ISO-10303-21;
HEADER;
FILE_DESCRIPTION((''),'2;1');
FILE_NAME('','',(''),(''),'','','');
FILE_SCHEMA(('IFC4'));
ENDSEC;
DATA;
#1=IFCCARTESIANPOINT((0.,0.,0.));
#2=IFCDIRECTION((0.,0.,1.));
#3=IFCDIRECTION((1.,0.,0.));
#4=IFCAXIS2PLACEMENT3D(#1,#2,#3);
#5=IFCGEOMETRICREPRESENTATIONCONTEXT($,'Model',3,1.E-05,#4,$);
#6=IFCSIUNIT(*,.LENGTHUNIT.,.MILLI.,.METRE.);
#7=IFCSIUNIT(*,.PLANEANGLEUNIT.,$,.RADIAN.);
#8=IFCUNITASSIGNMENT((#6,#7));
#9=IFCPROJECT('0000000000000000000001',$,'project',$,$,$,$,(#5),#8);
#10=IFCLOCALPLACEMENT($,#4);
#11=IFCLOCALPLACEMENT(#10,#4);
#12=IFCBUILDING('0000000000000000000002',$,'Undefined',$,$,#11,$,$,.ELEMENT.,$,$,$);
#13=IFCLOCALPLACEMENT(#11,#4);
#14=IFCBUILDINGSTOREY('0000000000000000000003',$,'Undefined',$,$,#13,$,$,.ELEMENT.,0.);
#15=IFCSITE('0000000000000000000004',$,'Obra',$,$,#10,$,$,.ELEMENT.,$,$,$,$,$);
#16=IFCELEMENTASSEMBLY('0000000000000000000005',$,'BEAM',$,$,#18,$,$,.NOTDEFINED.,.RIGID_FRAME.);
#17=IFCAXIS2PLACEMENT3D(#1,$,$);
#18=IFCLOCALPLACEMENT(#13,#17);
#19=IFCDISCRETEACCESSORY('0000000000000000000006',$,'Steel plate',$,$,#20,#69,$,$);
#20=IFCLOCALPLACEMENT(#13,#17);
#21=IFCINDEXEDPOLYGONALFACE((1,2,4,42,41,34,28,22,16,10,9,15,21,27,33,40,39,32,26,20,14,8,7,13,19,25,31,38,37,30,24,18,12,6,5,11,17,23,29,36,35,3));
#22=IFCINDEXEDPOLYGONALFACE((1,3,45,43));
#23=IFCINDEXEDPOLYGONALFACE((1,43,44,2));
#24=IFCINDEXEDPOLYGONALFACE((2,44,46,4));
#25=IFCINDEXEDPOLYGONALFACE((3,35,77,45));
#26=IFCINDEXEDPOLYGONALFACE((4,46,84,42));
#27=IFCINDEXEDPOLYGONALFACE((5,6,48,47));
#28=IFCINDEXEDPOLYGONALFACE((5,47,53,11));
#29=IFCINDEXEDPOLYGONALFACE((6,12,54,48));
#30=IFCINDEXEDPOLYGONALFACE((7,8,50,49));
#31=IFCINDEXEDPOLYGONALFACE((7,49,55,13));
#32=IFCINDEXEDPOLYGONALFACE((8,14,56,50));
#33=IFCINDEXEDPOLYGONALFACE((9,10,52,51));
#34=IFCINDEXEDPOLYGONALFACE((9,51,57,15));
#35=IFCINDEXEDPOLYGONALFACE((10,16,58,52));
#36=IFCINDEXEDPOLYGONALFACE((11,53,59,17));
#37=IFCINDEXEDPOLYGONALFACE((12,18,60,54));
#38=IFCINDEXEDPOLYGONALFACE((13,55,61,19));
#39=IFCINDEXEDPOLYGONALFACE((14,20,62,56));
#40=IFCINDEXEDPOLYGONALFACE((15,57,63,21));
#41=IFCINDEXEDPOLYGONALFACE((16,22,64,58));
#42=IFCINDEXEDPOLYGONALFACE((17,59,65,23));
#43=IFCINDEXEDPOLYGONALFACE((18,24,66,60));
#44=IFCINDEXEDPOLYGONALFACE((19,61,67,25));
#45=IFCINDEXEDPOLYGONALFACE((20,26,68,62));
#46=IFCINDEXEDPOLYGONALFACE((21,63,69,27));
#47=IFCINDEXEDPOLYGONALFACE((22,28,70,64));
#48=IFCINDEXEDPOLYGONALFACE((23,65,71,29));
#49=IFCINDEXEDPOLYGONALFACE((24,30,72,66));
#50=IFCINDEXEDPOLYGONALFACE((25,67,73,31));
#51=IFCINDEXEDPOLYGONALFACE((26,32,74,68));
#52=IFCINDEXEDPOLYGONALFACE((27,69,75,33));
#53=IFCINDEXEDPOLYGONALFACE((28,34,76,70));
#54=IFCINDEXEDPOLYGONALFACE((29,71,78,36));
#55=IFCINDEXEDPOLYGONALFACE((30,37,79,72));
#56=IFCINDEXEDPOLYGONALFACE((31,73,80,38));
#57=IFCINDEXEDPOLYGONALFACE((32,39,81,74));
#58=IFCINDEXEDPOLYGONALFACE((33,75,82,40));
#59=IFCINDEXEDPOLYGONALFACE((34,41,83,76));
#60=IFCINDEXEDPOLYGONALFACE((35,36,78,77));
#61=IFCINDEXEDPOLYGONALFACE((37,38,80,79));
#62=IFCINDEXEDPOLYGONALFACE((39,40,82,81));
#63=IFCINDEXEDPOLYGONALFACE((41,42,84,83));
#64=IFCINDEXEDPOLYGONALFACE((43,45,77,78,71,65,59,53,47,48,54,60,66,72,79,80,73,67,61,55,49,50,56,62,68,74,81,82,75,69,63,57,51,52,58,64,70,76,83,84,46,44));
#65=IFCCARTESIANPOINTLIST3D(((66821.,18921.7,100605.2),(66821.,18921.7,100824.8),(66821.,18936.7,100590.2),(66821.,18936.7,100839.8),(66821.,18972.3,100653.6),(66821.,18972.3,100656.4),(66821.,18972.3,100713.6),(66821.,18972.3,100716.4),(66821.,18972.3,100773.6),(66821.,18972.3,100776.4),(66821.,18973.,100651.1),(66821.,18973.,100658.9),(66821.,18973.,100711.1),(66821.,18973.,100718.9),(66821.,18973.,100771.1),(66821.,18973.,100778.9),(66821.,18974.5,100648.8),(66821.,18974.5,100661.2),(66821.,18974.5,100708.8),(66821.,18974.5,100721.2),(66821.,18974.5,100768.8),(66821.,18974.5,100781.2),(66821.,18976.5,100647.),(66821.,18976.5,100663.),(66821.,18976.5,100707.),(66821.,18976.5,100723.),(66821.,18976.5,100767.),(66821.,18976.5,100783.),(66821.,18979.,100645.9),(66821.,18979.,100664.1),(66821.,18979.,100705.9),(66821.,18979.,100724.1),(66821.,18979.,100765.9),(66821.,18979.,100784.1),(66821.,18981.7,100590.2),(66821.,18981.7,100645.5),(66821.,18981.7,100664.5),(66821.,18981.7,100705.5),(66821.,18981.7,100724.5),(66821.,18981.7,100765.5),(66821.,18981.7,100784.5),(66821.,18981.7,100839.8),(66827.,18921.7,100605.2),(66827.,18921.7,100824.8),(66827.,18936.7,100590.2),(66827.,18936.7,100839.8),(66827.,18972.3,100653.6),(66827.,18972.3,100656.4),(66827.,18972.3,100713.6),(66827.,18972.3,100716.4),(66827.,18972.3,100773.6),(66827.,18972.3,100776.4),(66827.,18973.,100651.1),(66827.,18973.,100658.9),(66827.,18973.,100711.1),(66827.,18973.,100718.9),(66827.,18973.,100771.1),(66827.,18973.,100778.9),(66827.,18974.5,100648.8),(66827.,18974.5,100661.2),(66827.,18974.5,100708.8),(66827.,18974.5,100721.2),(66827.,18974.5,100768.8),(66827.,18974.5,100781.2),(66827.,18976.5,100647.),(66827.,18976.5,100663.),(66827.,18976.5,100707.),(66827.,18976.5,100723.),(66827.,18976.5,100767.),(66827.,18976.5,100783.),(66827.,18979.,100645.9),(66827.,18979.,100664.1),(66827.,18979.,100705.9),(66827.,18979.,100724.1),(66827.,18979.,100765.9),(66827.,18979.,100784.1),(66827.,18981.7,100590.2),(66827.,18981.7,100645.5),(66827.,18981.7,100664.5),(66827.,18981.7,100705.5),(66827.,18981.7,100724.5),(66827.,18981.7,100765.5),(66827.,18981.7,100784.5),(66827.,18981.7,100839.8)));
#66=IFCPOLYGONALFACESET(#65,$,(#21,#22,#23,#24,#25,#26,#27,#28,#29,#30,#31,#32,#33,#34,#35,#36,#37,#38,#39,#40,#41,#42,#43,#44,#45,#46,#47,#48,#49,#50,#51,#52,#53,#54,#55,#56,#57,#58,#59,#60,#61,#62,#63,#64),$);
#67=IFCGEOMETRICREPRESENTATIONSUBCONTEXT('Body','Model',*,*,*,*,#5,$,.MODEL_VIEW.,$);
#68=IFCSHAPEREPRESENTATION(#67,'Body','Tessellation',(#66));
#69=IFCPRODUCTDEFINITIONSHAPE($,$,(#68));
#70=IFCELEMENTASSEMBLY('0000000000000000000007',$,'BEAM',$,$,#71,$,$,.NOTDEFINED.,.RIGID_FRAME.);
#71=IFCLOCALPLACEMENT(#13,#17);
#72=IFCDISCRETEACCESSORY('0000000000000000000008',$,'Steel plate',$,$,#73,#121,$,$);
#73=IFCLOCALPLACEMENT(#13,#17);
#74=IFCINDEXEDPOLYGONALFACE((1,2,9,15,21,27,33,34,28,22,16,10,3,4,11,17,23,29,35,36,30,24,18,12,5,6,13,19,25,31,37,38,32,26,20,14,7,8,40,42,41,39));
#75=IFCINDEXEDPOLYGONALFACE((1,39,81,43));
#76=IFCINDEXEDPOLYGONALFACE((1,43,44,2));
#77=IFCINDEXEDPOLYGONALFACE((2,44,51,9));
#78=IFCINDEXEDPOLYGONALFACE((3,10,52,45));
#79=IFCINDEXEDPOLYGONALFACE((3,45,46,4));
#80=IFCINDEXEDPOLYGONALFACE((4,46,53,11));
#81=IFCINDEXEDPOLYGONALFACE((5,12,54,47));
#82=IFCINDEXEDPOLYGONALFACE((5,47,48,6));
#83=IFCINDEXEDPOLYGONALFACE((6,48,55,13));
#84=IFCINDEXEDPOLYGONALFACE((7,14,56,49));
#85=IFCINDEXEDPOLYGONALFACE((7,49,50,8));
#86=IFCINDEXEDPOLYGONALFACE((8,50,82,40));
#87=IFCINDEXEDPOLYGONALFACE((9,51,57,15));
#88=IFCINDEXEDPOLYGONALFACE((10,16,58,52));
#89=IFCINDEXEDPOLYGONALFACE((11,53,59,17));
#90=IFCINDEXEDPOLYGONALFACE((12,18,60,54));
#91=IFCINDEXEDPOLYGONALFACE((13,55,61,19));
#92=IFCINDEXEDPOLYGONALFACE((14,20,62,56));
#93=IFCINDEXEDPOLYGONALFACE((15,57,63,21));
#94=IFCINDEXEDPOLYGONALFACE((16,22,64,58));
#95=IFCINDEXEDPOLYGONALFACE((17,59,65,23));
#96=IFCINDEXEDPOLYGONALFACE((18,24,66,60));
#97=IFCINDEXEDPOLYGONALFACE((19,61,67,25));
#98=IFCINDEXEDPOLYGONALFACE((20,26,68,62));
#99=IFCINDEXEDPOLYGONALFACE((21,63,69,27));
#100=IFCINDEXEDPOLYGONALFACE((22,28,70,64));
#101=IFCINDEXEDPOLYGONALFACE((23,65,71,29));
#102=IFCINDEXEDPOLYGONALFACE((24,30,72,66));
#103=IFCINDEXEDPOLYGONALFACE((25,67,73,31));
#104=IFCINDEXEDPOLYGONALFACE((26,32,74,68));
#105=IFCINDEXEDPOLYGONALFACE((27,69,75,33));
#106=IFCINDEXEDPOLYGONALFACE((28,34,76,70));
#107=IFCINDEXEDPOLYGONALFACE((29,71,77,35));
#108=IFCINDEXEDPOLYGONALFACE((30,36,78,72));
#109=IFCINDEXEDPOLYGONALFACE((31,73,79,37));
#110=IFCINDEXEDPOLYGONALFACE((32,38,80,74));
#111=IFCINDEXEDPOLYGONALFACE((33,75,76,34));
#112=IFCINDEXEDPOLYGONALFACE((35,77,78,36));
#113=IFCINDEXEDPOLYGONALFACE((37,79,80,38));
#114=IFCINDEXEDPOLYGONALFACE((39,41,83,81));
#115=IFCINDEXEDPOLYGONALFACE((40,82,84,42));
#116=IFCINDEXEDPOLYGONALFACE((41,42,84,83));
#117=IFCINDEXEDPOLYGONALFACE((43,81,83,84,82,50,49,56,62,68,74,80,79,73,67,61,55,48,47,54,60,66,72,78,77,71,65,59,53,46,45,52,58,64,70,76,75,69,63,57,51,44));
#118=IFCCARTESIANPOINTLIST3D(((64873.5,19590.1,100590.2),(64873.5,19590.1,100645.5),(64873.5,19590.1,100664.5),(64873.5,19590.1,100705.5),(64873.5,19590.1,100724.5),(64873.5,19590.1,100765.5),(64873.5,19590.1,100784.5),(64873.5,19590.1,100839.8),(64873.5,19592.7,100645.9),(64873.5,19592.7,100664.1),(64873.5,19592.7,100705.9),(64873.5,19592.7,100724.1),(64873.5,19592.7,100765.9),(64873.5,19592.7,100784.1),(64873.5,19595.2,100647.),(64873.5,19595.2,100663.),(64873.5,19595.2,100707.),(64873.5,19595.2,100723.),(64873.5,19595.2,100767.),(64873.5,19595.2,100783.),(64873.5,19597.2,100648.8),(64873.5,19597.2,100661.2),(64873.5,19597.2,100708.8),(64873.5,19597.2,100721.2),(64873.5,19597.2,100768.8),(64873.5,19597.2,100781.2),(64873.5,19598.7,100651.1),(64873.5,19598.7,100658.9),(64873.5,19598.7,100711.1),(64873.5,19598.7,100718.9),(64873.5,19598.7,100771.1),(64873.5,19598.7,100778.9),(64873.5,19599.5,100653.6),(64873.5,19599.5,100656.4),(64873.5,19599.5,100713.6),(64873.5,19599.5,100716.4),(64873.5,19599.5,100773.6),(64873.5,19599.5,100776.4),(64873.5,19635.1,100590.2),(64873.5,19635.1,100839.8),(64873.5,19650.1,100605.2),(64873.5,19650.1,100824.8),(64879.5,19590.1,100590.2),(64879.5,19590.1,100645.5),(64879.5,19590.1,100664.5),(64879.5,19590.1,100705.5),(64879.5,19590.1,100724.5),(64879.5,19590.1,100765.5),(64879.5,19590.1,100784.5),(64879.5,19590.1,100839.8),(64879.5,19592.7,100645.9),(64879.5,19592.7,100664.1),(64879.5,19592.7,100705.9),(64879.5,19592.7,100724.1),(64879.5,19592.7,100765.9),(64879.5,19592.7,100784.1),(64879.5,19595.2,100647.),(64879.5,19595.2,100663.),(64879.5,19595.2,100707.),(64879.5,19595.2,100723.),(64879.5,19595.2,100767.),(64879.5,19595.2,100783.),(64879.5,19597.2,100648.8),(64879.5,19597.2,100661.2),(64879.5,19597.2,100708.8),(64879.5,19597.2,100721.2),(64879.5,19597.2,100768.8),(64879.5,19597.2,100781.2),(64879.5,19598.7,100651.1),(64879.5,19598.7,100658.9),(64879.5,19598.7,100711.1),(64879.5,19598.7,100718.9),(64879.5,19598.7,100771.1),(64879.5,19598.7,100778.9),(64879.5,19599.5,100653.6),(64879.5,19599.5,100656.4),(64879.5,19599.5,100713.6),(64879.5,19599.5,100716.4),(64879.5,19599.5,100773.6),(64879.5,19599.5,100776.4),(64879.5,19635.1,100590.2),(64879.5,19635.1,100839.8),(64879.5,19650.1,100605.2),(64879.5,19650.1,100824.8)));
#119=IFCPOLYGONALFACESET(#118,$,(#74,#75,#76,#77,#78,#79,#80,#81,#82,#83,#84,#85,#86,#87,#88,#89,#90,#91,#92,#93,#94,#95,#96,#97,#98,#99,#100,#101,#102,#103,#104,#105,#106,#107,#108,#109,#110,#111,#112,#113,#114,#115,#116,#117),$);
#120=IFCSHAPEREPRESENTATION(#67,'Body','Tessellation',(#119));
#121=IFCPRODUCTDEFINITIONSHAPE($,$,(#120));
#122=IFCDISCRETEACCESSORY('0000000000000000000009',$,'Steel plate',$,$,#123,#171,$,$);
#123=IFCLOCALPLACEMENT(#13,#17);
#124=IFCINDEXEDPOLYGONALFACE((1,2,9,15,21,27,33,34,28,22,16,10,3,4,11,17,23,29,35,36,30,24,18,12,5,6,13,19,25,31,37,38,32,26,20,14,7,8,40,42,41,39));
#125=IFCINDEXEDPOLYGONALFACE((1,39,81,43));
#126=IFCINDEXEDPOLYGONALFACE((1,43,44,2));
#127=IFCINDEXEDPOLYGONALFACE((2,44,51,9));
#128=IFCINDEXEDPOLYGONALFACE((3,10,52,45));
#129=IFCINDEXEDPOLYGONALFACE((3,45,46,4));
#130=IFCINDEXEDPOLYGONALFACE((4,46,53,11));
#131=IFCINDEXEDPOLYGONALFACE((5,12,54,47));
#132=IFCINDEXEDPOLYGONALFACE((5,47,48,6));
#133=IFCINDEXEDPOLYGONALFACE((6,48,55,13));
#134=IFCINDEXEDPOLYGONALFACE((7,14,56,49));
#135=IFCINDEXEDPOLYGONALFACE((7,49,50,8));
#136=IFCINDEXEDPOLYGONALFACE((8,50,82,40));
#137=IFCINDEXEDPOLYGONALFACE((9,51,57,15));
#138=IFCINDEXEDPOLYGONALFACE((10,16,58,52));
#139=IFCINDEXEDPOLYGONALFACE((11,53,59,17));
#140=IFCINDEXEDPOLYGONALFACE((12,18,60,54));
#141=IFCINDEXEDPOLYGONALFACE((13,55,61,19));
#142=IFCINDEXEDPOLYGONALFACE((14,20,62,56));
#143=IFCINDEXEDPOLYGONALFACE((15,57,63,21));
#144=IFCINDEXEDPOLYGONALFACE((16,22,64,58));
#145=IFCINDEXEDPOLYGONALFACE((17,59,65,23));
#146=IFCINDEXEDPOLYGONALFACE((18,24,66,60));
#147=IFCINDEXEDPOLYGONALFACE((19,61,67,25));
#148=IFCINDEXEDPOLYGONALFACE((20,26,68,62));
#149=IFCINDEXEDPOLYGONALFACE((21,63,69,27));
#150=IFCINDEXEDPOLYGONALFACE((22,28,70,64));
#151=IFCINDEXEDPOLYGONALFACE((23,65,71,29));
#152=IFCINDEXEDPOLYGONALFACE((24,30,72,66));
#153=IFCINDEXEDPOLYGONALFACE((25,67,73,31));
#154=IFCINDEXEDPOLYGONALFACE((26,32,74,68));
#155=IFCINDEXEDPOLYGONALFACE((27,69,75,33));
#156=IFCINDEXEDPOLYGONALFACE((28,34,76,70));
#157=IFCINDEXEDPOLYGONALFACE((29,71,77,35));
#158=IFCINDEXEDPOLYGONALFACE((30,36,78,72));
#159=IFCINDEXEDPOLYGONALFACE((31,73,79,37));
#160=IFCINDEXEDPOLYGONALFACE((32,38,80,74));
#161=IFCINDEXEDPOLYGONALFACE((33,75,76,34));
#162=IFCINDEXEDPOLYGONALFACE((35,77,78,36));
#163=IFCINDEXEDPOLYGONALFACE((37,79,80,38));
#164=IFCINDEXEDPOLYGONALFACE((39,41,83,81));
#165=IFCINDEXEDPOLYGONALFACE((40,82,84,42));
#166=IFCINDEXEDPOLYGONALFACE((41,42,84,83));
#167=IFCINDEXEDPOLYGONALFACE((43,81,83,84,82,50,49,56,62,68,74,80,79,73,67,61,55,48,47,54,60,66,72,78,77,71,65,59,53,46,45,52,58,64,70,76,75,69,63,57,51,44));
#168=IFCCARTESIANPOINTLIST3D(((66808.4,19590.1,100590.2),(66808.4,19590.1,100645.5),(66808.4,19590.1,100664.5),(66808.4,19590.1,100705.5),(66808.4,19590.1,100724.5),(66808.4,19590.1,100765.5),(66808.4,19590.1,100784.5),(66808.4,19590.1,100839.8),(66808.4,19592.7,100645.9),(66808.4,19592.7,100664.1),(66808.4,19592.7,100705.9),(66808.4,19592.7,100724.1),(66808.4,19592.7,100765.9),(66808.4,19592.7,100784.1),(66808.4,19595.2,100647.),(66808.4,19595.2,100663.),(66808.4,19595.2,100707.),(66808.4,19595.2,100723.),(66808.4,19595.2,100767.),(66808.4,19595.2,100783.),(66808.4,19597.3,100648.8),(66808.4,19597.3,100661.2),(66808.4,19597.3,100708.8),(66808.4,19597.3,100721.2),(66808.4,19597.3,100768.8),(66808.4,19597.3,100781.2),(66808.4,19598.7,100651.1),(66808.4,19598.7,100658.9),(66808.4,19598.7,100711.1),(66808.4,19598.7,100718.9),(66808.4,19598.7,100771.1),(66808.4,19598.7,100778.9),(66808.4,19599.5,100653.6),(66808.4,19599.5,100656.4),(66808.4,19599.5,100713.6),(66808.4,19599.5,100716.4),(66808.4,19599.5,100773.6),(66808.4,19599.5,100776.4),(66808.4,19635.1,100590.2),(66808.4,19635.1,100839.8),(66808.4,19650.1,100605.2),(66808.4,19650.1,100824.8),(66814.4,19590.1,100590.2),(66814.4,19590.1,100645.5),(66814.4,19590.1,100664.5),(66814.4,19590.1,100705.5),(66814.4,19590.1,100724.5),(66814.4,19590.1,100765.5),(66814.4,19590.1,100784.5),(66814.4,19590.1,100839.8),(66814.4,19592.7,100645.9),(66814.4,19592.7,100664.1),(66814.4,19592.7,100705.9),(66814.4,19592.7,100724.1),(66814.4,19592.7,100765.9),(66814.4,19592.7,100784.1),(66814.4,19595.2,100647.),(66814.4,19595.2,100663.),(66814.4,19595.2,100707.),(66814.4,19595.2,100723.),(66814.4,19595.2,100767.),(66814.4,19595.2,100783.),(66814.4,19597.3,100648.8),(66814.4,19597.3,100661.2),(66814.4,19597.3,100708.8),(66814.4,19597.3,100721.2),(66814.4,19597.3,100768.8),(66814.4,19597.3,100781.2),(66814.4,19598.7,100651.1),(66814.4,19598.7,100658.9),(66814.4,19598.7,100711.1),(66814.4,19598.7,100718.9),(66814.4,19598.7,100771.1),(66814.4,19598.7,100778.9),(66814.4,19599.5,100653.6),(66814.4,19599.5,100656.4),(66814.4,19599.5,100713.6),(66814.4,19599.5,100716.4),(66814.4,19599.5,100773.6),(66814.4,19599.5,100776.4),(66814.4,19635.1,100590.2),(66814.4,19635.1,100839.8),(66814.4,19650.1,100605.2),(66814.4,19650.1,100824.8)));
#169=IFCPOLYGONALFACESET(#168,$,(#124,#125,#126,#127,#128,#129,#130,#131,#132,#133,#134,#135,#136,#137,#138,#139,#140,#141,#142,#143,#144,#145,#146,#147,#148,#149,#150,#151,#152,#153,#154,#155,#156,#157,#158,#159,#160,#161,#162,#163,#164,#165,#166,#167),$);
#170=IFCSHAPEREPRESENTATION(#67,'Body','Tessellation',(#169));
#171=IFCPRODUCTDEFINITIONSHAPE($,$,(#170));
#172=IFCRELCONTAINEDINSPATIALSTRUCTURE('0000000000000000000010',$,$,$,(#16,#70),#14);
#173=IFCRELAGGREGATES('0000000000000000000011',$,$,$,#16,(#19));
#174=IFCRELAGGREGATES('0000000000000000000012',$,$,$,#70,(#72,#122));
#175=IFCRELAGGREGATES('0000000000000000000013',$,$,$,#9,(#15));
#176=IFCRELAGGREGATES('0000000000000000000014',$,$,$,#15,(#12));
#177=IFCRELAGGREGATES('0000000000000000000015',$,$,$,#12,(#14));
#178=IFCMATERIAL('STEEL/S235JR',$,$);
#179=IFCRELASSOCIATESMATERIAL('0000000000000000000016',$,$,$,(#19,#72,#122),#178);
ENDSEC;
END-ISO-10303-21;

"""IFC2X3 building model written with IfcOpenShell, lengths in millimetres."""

from ifc_helpers import new_model, si_unit, frame, origin_with_axes, origin_2d_with_axis, place, context, subcontext, project, spatial, polyline, circle, outline, extrude, source, transform, mapped, material, element, aggregate, save


model = new_model("IFC2X3")

# Units and contexts
model_context = context("Model", 3, precision=1e-05, world=origin_with_axes())
body_context = subcontext(model_context, "Body", "Model", "MODEL_VIEW")
ifc_project = project(units=[si_unit("LENGTHUNIT", "METRE", prefix="MILLI"), si_unit("PLANEANGLEUNIT", "RADIAN")], contexts=[model_context])

# Site, building, storey
site_placement = place(None, origin_with_axes())
site = spatial("IfcSite", under=ifc_project, at=site_placement, Name="Obra", CompositionType="ELEMENT")
building_placement = place(site_placement, origin_with_axes())
building = spatial("IfcBuilding", under=site, at=building_placement, Name="Undefined", CompositionType="ELEMENT")
storey_placement = place(building_placement, origin_with_axes())
storey = spatial("IfcBuildingStorey", under=building, at=storey_placement, Name="Undefined", CompositionType="ELEMENT", Elevation=0.0)

# Shared definitions
ifc_material = material(Name="STEEL/S235JR")

# Element assemblies, discrete accessories, openings
assembly_1_placement = place(storey_placement, origin_with_axes())
assembly_1 = element("IfcElementAssembly", 1, at=assembly_1_placement, inside=storey, Name="BEAM", AssemblyPlace="NOTDEFINED", PredefinedType="RIGID_FRAME")
shared_shape_1 = source(origin_with_axes(), body_context, "Body", "SweptSolid", [
    extrude(circle(Radius=9.5, at=origin_2d_with_axis()), frame((0.0, -9.4, 0.0), z_axis=(0.0, 1.0, 0.0), x_axis=(1.0, 0.0, 0.0)), (0.0, 0.0, 1.0), 6.2),
])
discrete_accessory_1_placement = place(assembly_1_placement, frame((66824.0, 18981.7, 100590.2), z_axis=(-1.0, -0.000002, 0.0), x_axis=(0.000002, -1.0, 0.0)))
discrete_accessory_1 = element("IfcDiscreteAccessory", 2, at=discrete_accessory_1_placement, material=ifc_material, Name="Steel plate", context=body_context, shape_type="SweptSolid", body=[
    extrude(outline(polyline([(0.0, 0.0), (45.0, 0.0), (60.0, 15.0), (60.0, 234.6), (45.0, 249.6), (0.0, 249.6), (0.0, 0.0)])), frame((0.0, 0.0, -3.0), z_axis=(0.0, 0.0, 1.0), x_axis=(1.0, 0.0, 0.0)), (0.0, 0.0, 1.0), 6.0),
])
opening_1_placement = place(assembly_1_placement, frame((66817.7, 18931.7, 100850.0), z_axis=(-0.000002, 1.0, 0.0), x_axis=(0.0, 0.0, -1.0)))
element("IfcOpeningElement", 3, at=opening_1_placement, cuts=discrete_accessory_1, ObjectType="Opening", context=body_context, shape_type="MappedRepresentation", body=[
    mapped(shared_shape_1, transform((75.0, 0.0, 50.0))),
    mapped(shared_shape_1, transform((135.0, 0.0, 50.0))),
    mapped(shared_shape_1, transform((195.0, 0.0, 50.0))),
])
aggregate(assembly_1, [discrete_accessory_1])
assembly_2_placement = place(storey_placement, origin_with_axes())
assembly_2 = element("IfcElementAssembly", 4, at=assembly_2_placement, inside=storey, Name="BEAM", AssemblyPlace="NOTDEFINED", PredefinedType="RIGID_FRAME")
discrete_accessory_2_placement = place(assembly_2_placement, frame((64876.5, 19590.1, 100590.2), z_axis=(1.0, 0.000001, 0.0), x_axis=(-0.000002, 1.0, 0.0)))
discrete_accessory_2 = element("IfcDiscreteAccessory", 5, at=discrete_accessory_2_placement, material=ifc_material, Name="Steel plate", context=body_context, shape_type="SweptSolid", body=[
    extrude(outline(polyline([(0.0, 0.0), (45.0, 0.0), (60.0, 15.0), (60.0, 234.6), (45.0, 249.6), (0.0, 249.6), (0.0, 0.0)])), frame((0.0, 0.0, -3.0), z_axis=(0.0, 0.0, 1.0), x_axis=(1.0, 0.0, 0.0)), (0.0, 0.0, 1.0), 6.0),
])
opening_2_placement = place(assembly_2_placement, frame((64882.8, 19640.1, 100850.0), z_axis=(0.000002, -1.0, 0.0), x_axis=(0.0, 0.0, -1.0)))
element("IfcOpeningElement", 6, at=opening_2_placement, cuts=discrete_accessory_2, ObjectType="Opening", context=body_context, shape_type="MappedRepresentation", body=[
    mapped(shared_shape_1, transform((75.0, 0.0, 50.0))),
    mapped(shared_shape_1, transform((135.0, 0.0, 50.0))),
    mapped(shared_shape_1, transform((195.0, 0.0, 50.0))),
])
discrete_accessory_3_placement = place(assembly_2_placement, frame((66811.4, 19590.1, 100590.2), z_axis=(1.0, 0.000001, 0.0), x_axis=(-0.000002, 1.0, 0.0)))
discrete_accessory_3 = element("IfcDiscreteAccessory", 7, at=discrete_accessory_3_placement, material=ifc_material, Name="Steel plate", context=body_context, shape_type="SweptSolid", body=[
    extrude(outline(polyline([(0.0, 0.0), (45.0, 0.0), (60.0, 15.0), (60.0, 234.6), (45.0, 249.6), (0.0, 249.6), (0.0, 0.0)])), frame((0.0, 0.0, -3.0), z_axis=(0.0, 0.0, 1.0), x_axis=(1.0, 0.0, 0.0)), (0.0, 0.0, 1.0), 6.0),
])
opening_3_placement = place(assembly_2_placement, frame((66817.7, 19640.1, 100850.0), z_axis=(0.000002, -1.0, 0.0), x_axis=(0.0, 0.0, -1.0)))
element("IfcOpeningElement", 8, at=opening_3_placement, cuts=discrete_accessory_3, ObjectType="Opening", context=body_context, shape_type="MappedRepresentation", body=[
    mapped(shared_shape_1, transform((75.0, 0.0, 50.0))),
    mapped(shared_shape_1, transform((135.0, 0.0, 50.0))),
    mapped(shared_shape_1, transform((195.0, 0.0, 50.0))),
])
aggregate(assembly_2, [discrete_accessory_2, discrete_accessory_3])

save(model, "model.ifc")
